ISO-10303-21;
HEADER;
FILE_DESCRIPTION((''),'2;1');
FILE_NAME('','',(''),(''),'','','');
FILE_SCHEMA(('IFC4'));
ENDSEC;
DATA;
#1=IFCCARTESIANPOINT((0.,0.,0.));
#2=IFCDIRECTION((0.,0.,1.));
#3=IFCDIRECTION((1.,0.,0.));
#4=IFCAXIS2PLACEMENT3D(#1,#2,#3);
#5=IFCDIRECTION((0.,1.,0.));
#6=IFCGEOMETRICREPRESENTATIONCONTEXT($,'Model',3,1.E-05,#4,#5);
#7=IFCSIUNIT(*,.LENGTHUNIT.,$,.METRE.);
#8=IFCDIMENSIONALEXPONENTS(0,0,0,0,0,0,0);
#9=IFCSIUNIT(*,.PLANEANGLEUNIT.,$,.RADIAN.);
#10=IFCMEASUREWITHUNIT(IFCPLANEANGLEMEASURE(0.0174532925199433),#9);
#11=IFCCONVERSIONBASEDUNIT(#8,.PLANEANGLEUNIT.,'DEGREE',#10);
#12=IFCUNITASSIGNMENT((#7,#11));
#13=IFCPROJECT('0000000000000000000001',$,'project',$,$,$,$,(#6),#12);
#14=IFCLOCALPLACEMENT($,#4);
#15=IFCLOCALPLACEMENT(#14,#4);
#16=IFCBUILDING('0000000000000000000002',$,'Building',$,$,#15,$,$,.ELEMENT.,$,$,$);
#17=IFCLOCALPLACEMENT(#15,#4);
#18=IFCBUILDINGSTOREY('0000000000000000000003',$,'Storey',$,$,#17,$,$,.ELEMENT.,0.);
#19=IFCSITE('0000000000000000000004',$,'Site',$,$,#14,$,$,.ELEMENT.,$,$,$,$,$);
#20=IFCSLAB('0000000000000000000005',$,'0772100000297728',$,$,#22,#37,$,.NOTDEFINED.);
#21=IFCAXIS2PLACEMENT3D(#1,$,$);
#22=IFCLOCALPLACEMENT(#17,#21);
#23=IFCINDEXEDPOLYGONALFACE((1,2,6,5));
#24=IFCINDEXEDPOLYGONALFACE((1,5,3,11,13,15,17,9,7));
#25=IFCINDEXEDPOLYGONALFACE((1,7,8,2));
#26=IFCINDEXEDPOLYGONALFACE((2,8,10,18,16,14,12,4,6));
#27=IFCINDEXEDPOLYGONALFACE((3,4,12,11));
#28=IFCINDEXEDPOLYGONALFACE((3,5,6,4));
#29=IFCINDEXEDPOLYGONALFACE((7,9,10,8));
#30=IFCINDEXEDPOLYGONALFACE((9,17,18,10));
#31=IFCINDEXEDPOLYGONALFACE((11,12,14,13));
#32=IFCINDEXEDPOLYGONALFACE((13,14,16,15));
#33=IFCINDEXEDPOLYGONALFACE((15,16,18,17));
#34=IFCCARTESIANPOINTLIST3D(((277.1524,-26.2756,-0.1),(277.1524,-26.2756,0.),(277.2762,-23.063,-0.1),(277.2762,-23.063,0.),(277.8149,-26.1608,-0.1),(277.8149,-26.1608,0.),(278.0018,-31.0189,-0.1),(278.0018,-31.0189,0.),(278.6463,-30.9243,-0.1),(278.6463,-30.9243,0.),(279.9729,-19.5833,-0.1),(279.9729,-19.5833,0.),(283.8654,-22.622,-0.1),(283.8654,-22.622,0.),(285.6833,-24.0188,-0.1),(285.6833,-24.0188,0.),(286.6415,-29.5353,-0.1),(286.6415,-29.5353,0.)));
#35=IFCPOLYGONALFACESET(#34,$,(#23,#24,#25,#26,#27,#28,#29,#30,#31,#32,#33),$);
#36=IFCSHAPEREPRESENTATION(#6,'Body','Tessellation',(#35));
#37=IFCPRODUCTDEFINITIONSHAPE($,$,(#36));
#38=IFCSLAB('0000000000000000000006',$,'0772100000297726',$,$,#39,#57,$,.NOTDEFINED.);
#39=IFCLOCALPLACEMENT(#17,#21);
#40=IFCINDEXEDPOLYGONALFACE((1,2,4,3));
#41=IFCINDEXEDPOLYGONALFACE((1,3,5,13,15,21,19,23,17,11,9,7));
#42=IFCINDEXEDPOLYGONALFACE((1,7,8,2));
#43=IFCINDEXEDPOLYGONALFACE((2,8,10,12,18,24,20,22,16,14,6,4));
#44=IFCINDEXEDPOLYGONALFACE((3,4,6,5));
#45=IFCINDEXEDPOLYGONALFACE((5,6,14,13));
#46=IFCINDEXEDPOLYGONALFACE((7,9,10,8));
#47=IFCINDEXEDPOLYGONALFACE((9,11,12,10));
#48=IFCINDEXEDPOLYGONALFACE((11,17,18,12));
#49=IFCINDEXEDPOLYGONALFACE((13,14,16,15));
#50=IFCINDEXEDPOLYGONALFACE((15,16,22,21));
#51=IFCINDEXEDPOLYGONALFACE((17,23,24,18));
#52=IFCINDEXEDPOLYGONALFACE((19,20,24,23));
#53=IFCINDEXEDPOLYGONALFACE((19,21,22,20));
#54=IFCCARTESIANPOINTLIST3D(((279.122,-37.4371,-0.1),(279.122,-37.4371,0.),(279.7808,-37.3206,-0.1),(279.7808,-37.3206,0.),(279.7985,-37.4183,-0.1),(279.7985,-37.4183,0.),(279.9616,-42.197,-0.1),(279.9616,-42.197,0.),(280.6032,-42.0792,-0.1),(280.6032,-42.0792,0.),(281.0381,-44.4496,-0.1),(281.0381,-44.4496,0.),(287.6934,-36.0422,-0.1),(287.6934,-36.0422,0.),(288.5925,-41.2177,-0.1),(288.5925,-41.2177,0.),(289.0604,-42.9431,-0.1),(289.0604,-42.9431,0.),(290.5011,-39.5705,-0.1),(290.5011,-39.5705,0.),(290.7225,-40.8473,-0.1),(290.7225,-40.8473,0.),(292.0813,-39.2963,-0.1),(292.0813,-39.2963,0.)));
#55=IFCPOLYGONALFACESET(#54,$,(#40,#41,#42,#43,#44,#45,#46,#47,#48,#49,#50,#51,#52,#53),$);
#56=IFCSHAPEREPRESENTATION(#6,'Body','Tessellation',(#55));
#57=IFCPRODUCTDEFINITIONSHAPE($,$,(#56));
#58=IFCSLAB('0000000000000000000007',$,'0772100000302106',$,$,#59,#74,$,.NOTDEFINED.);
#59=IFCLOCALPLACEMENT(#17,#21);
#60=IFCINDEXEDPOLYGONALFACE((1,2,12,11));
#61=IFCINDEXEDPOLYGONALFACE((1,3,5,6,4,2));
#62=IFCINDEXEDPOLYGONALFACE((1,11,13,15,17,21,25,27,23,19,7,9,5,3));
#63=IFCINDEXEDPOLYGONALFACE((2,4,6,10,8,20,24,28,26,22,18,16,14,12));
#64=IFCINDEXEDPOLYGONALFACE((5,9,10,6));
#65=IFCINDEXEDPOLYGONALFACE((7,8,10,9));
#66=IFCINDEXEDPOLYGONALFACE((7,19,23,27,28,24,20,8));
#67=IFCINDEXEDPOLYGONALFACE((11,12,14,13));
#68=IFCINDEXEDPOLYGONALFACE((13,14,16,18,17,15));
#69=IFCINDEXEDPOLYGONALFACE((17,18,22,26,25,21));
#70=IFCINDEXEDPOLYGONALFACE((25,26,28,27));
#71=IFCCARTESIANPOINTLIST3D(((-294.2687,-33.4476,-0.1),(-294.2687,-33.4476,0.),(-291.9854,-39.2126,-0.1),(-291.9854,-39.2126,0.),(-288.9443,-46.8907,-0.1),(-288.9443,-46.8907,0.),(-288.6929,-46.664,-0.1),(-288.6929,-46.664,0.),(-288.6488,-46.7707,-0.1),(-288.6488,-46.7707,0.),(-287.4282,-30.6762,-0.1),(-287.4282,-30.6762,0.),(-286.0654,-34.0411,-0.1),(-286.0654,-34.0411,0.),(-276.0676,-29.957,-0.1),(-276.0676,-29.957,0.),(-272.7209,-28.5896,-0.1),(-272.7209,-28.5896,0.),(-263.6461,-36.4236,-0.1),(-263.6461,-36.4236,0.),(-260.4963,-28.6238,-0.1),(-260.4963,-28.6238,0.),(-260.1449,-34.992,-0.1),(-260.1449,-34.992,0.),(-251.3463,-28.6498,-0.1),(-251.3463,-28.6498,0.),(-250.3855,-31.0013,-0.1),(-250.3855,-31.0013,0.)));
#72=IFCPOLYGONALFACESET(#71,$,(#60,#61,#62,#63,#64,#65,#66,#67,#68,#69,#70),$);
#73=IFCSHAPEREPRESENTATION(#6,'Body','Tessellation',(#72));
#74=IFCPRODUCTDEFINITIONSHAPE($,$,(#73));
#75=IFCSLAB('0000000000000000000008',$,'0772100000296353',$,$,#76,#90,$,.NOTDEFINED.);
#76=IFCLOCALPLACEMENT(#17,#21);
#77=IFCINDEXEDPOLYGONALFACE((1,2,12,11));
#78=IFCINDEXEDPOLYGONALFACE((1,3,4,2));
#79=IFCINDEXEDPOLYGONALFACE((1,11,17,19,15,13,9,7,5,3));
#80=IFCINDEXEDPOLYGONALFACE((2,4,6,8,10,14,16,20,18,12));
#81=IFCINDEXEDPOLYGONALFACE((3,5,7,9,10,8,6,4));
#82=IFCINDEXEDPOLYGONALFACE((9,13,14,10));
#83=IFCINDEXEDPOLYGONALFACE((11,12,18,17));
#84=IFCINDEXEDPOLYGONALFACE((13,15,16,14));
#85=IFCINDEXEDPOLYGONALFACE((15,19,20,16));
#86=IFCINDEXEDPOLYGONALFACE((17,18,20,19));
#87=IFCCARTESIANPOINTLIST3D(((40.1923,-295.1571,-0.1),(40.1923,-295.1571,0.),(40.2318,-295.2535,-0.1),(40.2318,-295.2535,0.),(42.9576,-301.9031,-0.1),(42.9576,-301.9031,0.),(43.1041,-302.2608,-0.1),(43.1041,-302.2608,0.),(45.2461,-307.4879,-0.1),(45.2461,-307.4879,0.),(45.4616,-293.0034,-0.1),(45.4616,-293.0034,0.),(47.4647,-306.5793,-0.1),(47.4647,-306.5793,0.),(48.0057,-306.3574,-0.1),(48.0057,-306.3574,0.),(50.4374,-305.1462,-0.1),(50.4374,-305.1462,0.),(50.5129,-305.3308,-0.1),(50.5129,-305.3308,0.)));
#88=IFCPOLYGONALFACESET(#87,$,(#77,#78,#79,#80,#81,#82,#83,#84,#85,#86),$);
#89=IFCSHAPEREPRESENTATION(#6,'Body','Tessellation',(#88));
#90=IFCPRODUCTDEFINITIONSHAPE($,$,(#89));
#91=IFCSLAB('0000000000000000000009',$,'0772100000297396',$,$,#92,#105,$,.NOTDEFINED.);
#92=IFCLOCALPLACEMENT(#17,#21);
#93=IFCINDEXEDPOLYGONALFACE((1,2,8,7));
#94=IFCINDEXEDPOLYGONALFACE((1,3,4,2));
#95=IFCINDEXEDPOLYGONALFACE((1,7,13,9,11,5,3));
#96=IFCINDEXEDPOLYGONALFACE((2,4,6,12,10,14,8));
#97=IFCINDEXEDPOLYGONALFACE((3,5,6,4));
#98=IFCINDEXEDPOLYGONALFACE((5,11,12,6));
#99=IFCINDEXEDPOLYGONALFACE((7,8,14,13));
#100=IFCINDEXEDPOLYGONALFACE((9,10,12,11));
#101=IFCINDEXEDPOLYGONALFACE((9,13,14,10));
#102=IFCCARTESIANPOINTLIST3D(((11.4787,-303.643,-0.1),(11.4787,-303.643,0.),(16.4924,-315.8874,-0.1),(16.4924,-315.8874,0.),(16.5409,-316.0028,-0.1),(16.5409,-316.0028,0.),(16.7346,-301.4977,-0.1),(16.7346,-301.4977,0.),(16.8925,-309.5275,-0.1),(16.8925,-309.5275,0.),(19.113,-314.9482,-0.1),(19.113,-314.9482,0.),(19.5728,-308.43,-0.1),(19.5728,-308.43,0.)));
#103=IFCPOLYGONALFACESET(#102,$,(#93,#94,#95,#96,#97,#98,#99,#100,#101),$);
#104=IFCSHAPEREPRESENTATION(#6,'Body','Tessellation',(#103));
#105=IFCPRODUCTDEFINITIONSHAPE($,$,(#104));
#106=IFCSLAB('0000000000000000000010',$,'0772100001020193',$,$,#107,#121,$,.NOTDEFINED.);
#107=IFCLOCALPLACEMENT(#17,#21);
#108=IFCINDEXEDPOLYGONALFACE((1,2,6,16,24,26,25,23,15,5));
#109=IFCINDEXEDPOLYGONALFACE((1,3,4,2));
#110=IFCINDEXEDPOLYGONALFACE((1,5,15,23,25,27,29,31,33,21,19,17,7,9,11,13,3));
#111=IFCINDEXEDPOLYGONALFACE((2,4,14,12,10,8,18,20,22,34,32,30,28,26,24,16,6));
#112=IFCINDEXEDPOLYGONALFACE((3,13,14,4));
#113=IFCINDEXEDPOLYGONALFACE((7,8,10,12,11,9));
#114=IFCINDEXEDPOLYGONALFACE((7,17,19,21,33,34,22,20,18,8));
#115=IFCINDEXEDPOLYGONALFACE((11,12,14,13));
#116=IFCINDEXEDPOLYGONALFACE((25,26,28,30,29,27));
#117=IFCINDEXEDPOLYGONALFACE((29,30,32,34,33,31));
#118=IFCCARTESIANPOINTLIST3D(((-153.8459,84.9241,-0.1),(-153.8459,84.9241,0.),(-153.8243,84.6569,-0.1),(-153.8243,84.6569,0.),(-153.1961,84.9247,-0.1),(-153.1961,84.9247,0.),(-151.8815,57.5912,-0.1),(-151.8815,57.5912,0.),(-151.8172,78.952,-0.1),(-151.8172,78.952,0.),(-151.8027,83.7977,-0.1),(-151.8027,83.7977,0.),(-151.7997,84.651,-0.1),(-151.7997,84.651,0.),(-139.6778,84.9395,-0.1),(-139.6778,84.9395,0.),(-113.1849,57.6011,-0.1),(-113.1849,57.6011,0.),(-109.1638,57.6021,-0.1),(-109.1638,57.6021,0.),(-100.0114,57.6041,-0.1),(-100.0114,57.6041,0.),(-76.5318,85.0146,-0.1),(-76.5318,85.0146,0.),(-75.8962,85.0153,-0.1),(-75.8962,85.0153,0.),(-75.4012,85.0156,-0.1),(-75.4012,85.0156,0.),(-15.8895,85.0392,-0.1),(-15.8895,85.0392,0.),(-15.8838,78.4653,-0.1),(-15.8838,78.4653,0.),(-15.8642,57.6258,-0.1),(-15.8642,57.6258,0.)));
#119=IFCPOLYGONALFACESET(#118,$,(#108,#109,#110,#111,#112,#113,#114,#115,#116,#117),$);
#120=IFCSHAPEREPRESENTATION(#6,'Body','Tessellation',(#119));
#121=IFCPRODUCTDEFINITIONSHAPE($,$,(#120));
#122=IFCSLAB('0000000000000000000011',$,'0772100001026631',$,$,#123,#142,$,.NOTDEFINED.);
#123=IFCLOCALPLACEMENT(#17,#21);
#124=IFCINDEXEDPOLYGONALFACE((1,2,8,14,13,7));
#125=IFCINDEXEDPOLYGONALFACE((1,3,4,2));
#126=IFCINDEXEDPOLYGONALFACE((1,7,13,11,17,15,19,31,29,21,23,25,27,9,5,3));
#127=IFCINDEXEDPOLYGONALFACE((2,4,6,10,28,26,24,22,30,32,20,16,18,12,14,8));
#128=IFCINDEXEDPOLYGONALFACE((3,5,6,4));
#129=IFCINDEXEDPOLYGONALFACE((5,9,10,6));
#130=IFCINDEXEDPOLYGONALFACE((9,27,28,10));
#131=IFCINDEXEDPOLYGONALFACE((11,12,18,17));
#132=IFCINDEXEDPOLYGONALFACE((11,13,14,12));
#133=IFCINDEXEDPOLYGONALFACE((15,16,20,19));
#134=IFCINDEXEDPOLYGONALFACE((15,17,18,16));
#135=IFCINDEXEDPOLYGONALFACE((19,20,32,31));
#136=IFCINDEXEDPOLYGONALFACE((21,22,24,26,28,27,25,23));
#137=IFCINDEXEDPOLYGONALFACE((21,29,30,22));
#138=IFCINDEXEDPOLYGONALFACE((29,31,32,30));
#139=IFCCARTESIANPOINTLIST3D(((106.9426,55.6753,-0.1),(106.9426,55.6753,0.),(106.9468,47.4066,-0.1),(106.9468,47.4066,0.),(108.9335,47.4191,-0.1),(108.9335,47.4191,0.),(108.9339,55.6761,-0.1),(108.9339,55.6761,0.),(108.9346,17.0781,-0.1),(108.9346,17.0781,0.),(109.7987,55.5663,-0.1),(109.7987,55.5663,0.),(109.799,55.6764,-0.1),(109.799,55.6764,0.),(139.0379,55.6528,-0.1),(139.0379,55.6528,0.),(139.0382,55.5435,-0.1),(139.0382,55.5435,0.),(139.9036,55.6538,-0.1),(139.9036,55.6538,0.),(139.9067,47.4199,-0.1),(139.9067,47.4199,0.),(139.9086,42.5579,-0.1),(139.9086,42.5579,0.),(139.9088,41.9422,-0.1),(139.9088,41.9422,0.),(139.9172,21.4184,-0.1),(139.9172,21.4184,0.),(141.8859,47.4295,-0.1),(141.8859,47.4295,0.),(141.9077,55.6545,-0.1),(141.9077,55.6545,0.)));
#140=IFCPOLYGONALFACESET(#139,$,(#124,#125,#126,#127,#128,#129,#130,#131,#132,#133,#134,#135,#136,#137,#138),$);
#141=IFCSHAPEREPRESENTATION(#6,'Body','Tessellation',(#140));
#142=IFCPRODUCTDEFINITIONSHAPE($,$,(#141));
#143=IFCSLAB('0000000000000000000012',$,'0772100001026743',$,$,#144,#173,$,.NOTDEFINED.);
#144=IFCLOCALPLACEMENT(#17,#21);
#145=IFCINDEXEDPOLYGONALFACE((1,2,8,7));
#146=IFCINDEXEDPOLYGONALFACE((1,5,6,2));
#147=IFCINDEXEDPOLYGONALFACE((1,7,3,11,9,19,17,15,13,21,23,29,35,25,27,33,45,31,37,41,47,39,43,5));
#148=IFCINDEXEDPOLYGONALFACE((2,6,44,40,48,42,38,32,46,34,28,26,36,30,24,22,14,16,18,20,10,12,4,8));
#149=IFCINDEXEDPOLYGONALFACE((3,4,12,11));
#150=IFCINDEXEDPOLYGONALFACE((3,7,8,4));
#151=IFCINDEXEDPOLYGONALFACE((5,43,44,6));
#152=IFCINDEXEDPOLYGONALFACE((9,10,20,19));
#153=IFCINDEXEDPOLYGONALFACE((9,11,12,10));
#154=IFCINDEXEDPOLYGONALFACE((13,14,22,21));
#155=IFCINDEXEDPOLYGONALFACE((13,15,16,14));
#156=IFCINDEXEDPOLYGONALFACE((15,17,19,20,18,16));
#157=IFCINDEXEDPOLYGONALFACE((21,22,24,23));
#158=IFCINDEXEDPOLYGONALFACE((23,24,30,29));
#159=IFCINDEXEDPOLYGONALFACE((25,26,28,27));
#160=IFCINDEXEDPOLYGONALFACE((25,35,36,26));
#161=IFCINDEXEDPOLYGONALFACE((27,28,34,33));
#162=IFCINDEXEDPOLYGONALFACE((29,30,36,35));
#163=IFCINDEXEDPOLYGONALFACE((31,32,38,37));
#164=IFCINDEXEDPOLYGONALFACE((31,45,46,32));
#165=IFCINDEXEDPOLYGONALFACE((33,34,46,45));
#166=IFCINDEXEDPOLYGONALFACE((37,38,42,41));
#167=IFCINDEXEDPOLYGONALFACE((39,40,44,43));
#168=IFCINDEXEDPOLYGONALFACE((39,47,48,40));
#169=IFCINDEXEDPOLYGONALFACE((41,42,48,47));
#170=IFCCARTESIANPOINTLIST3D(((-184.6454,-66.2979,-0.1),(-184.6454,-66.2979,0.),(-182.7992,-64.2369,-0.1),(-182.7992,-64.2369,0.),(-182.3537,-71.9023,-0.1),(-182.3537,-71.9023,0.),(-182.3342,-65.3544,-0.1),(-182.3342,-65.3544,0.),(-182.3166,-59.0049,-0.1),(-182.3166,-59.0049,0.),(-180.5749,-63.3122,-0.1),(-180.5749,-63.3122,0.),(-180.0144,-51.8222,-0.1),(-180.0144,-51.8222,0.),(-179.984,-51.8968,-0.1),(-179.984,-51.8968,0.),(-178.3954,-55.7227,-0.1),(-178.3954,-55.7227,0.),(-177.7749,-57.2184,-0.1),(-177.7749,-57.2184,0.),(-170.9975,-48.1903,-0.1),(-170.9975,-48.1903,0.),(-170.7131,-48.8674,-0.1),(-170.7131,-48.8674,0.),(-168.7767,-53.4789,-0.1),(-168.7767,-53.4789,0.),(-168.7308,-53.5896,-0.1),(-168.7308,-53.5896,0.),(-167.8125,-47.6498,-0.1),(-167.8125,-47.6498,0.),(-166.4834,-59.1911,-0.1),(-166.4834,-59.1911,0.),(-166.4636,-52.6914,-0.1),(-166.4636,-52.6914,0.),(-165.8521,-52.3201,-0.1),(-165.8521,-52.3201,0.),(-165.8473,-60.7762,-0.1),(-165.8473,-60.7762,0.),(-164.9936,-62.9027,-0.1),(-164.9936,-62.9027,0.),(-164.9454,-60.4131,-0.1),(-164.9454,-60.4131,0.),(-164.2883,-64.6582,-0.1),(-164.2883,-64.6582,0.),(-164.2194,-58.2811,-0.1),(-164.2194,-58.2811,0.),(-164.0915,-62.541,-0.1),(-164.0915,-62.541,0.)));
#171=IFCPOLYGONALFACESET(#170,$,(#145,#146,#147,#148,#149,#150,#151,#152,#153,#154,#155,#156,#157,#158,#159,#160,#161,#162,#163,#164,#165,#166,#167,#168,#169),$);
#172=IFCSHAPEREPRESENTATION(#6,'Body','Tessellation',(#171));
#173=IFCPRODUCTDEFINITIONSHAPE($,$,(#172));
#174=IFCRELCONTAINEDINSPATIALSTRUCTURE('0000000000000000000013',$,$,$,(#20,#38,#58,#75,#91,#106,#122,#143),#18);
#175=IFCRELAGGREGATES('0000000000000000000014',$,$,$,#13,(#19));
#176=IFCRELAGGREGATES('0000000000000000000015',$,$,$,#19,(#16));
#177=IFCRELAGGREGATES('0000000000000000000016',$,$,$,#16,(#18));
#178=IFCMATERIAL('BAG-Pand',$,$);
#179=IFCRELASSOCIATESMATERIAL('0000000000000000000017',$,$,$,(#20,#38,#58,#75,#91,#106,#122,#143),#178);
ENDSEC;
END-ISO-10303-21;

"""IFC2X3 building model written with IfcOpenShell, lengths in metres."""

from ifc_helpers import new_model, entity, si_unit, converted_unit, direction, frame, origin_with_axes, place, context, project, spatial, polyline, outline, extrude, material, element, save


model = new_model("IFC2X3")

# Units and contexts
model_context = context("Model", 3, precision=1e-05, world=origin_with_axes(), true_north=direction((0.0, 1.0, 0.0)))
ifc_project = project(units=[si_unit("LENGTHUNIT", "METRE"), converted_unit("PLANEANGLEUNIT", "DEGREE", entity("IfcPlaneAngleMeasure", 0.0174532925199433), si_unit("PLANEANGLEUNIT", "RADIAN"), dimensions=[0, 0, 0, 0, 0, 0, 0])], contexts=[model_context])

# Site, building, storey
site_placement = place(None, origin_with_axes())
site = spatial("IfcSite", under=ifc_project, at=site_placement, Name="Site", CompositionType="ELEMENT")
building_placement = place(site_placement, origin_with_axes())
building = spatial("IfcBuilding", under=site, at=building_placement, Name="Building", CompositionType="ELEMENT")
storey_placement = place(building_placement, origin_with_axes())
storey = spatial("IfcBuildingStorey", under=building, at=storey_placement, Name="Storey", CompositionType="ELEMENT", Elevation=0.0)

# Slabs
ifc_material = material(Name="BAG-Pand")
slab_1_placement = place(storey_placement, frame((0.0, 0.0, -0.1), z_axis=(0.0, 0.0, 1.0), x_axis=(1.0, 0.0, 0.0)))
element("IfcSlab", 1, at=slab_1_placement, inside=storey, material=ifc_material, Name="0772100000297728", PredefinedType="NOTDEFINED", context=model_context, shape_type="SweptSolid", body=[
    extrude(outline(polyline([(277.1524, -26.2756), (277.8149, -26.1608), (277.2762, -23.063), (279.9729, -19.5833), (283.8654, -22.622), (285.6833, -24.0188), (286.6415, -29.5353), (278.6463, -30.9243), (278.0018, -31.0189), (277.1524, -26.2756)])), origin_with_axes(), (0.0, 0.0, 1.0), 0.1),
])
slab_2_placement = place(storey_placement, frame((0.0, 0.0, -0.1), z_axis=(0.0, 0.0, 1.0), x_axis=(1.0, 0.0, 0.0)))
element("IfcSlab", 2, at=slab_2_placement, inside=storey, material=ifc_material, Name="0772100000297726", PredefinedType="NOTDEFINED", context=model_context, shape_type="SweptSolid", body=[
    extrude(outline(polyline([(281.0381, -44.4496), (280.6032, -42.0792), (279.9616, -42.197), (279.122, -37.4371), (279.7808, -37.3206), (279.7985, -37.4183), (287.6934, -36.0422), (288.5925, -41.2177), (290.7225, -40.8473), (290.5011, -39.5705), (292.0813, -39.2963), (289.0604, -42.9431), (281.0381, -44.4496)])), origin_with_axes(), (0.0, 0.0, 1.0), 0.1),
])
slab_3_placement = place(storey_placement, frame((0.0, 0.0, -0.1), z_axis=(0.0, 0.0, 1.0), x_axis=(1.0, 0.0, 0.0)))
element("IfcSlab", 3, at=slab_3_placement, inside=storey, material=ifc_material, Name="0772100000302106", PredefinedType="NOTDEFINED", context=model_context, shape_type="SweptSolid", body=[
    extrude(outline(polyline([(-251.3463, -28.6498), (-250.3855, -31.0013), (-260.1449, -34.992), (-263.6461, -36.4236), (-288.6929, -46.664), (-288.6488, -46.7707), (-288.9443, -46.8907), (-291.9854, -39.2126), (-294.2687, -33.4476), (-287.4282, -30.6762), (-286.0654, -34.0411), (-276.0676, -29.957), (-272.7209, -28.5896), (-260.4963, -28.6238), (-251.3463, -28.6498)])), origin_with_axes(), (0.0, 0.0, 1.0), 0.1),
])
slab_4_placement = place(storey_placement, frame((0.0, 0.0, -0.1), z_axis=(0.0, 0.0, 1.0), x_axis=(1.0, 0.0, 0.0)))
element("IfcSlab", 4, at=slab_4_placement, inside=storey, material=ifc_material, Name="0772100000296353", PredefinedType="NOTDEFINED", context=model_context, shape_type="SweptSolid", body=[
    extrude(outline(polyline([(43.1041, -302.2608), (42.9576, -301.9031), (40.2318, -295.2535), (40.1923, -295.1571), (45.4616, -293.0034), (50.4374, -305.1462), (50.5129, -305.3308), (48.0057, -306.3574), (47.4647, -306.5793), (45.2461, -307.4879), (43.1041, -302.2608)])), origin_with_axes(), (0.0, 0.0, 1.0), 0.1),
])
slab_5_placement = place(storey_placement, frame((0.0, 0.0, -0.1), z_axis=(0.0, 0.0, 1.0), x_axis=(1.0, 0.0, 0.0)))
element("IfcSlab", 5, at=slab_5_placement, inside=storey, material=ifc_material, Name="0772100000297396", PredefinedType="NOTDEFINED", context=model_context, shape_type="SweptSolid", body=[
    extrude(outline(polyline([(16.7346, -301.4977), (19.5728, -308.43), (16.8925, -309.5275), (19.113, -314.9482), (16.5409, -316.0028), (16.4924, -315.8874), (11.4787, -303.643), (16.7346, -301.4977)])), origin_with_axes(), (0.0, 0.0, 1.0), 0.1),
])
slab_6_placement = place(storey_placement, frame((0.0, 0.0, -0.1), z_axis=(0.0, 0.0, 1.0), x_axis=(1.0, 0.0, 0.0)))
element("IfcSlab", 6, at=slab_6_placement, inside=storey, material=ifc_material, Name="0772100001020193", PredefinedType="NOTDEFINED", context=model_context, shape_type="SweptSolid", body=[
    extrude(outline(polyline([(-151.8172, 78.952), (-151.8027, 83.7977), (-151.7997, 84.651), (-153.8243, 84.6569), (-153.8459, 84.9241), (-153.1961, 84.9247), (-139.6778, 84.9395), (-76.5318, 85.0146), (-75.8962, 85.0153), (-75.4012, 85.0156), (-15.8895, 85.0392), (-15.8838, 78.4653), (-15.8642, 57.6258), (-100.0114, 57.6041), (-109.1638, 57.6021), (-113.1849, 57.6011), (-151.8815, 57.5912), (-151.8172, 78.952)])), origin_with_axes(), (0.0, 0.0, 1.0), 0.1),
])
slab_7_placement = place(storey_placement, frame((0.0, 0.0, -0.1), z_axis=(0.0, 0.0, 1.0), x_axis=(1.0, 0.0, 0.0)))
element("IfcSlab", 7, at=slab_7_placement, inside=storey, material=ifc_material, Name="0772100001026631", PredefinedType="NOTDEFINED", context=model_context, shape_type="SweptSolid", body=[
    extrude(outline(polyline([(108.9335, 47.4191), (106.9468, 47.4066), (106.9426, 55.6753), (108.9339, 55.6761), (109.799, 55.6764), (109.7987, 55.5663), (139.0382, 55.5435), (139.0379, 55.6528), (139.9036, 55.6538), (141.9077, 55.6545), (141.8859, 47.4295), (139.9067, 47.4199), (139.9086, 42.5579), (139.9088, 41.9422), (139.9172, 21.4184), (108.9346, 17.0781), (108.9335, 47.4191)])), origin_with_axes(), (0.0, 0.0, 1.0), 0.1),
])
slab_8_placement = place(storey_placement, frame((0.0, 0.0, -0.1), z_axis=(0.0, 0.0, 1.0), x_axis=(1.0, 0.0, 0.0)))
element("IfcSlab", 8, at=slab_8_placement, inside=storey, material=ifc_material, Name="0772100001026743", PredefinedType="NOTDEFINED", context=model_context, shape_type="SweptSolid", body=[
    extrude(outline(polyline([(-179.984, -51.8968), (-180.0144, -51.8222), (-170.9975, -48.1903), (-170.7131, -48.8674), (-167.8125, -47.6498), (-165.8521, -52.3201), (-168.7767, -53.4789), (-168.7308, -53.5896), (-166.4636, -52.6914), (-164.2194, -58.2811), (-166.4834, -59.1911), (-165.8473, -60.7762), (-164.9454, -60.4131), (-164.0915, -62.541), (-164.9936, -62.9027), (-164.2883, -64.6582), (-182.3537, -71.9023), (-184.6454, -66.2979), (-182.3342, -65.3544), (-182.7992, -64.2369), (-180.5749, -63.3122), (-182.3166, -59.0049), (-177.7749, -57.2184), (-178.3954, -55.7227), (-179.984, -51.8968)])), origin_with_axes(), (0.0, 0.0, 1.0), 0.1),
])

save(model, "model.ifc")
